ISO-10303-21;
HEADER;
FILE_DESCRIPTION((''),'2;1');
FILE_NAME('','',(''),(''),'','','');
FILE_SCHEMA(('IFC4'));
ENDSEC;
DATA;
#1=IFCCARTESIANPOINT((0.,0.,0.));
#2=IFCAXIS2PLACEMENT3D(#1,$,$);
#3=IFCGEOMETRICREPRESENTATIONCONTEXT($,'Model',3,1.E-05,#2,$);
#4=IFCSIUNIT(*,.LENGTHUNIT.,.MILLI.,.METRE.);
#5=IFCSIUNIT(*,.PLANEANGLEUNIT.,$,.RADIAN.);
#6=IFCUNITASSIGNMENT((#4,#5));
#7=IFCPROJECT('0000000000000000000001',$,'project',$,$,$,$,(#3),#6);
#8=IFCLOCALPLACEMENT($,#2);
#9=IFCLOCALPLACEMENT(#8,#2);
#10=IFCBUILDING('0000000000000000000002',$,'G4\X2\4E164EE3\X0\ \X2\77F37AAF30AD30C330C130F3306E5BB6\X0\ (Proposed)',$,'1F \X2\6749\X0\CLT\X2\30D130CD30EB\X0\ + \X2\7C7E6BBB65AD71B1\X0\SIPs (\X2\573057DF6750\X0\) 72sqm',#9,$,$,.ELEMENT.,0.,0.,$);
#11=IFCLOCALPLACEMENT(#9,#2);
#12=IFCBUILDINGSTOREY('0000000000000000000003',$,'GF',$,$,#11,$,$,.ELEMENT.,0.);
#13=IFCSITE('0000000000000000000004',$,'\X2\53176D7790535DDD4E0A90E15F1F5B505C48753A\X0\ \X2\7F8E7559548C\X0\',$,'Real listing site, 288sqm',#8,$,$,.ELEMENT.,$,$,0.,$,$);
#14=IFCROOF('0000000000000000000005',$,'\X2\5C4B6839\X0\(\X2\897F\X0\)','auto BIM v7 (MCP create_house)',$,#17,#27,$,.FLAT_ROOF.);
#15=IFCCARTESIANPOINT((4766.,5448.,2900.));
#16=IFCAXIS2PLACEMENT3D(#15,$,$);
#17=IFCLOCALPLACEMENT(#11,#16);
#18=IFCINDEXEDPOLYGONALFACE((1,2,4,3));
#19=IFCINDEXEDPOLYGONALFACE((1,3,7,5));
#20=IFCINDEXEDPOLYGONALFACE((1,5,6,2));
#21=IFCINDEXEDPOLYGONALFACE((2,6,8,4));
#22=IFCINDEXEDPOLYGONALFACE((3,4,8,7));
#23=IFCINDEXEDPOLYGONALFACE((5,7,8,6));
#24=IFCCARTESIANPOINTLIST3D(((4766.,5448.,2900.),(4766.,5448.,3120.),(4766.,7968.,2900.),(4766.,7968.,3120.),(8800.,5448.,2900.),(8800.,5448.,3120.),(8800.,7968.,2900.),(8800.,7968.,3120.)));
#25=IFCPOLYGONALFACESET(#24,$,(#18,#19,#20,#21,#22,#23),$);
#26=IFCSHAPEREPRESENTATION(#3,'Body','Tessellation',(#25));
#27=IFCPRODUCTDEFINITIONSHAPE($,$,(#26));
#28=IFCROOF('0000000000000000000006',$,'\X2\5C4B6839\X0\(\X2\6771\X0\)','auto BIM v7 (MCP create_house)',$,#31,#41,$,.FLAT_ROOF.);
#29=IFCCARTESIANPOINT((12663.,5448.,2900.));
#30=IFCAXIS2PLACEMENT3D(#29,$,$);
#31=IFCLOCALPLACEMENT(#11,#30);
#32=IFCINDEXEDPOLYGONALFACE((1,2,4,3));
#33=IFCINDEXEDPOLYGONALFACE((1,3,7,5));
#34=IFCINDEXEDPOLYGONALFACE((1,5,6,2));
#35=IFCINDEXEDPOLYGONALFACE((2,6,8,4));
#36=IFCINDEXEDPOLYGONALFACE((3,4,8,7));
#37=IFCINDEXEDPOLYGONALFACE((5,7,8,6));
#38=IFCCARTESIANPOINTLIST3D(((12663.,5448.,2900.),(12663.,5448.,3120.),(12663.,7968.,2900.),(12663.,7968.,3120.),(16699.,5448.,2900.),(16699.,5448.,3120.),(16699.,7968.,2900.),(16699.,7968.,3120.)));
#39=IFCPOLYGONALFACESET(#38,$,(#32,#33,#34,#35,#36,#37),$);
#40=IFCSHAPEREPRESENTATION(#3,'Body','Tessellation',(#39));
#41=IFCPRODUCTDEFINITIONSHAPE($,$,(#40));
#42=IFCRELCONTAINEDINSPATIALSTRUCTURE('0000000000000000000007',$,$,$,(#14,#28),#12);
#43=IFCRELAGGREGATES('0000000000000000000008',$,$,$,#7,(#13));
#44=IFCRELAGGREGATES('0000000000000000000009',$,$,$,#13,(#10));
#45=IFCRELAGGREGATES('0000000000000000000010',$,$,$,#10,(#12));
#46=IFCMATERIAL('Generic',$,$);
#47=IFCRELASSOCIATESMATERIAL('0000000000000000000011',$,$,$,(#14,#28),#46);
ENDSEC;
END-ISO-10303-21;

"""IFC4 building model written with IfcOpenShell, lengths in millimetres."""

from ifc_helpers import new_model, si_unit, frame, frame_2d, origin, place, context, project, spatial, rectangle, extrude, material, element, save


model = new_model("IFC4")

# Units and contexts
model_context = context("Model", 3, precision=1e-05, world=origin())
ifc_project = project(units=[si_unit("LENGTHUNIT", "METRE", prefix="MILLI"), si_unit("PLANEANGLEUNIT", "RADIAN")], contexts=[model_context])

# Site, building, storey
site_placement = place(None, origin())
site = spatial("IfcSite", under=ifc_project, at=site_placement, Name="北海道川上郡弟子屈町 美留和", ObjectType="Real listing site, 288sqm", CompositionType="ELEMENT", RefElevation=0.0)
building_placement = place(site_placement, origin())
building = spatial("IfcBuilding", under=site, at=building_placement, Name="G4世代 石窯キッチンの家 (Proposed)", ObjectType="1F 杉CLTパネル + 籾殻断熱SIPs (地域材) 72sqm", CompositionType="ELEMENT", ElevationOfRefHeight=0.0, ElevationOfTerrain=0.0)
storey_placement = place(building_placement, origin())
storey = spatial("IfcBuildingStorey", under=building, at=storey_placement, Name="GF", CompositionType="ELEMENT", Elevation=0.0)

# Shared definitions
ifc_material = material(Name="Generic")

# Roofs
roof_1_placement = place(storey_placement, frame((4766.0, 5448.0, 2900.0)))
element("IfcRoof", 1, at=roof_1_placement, inside=storey, material=ifc_material, Name="屋根(西)", Description="auto BIM v7 (MCP create_house)", PredefinedType="FLAT_ROOF", context=model_context, shape_type="SweptSolid", body=[
    extrude(rectangle(XDim=4034.0, YDim=2520.0, at=frame_2d((2017.0, 1260.0))), frame((4766.0, 5448.0, 2900.0)), (0.0, 0.0, 1.0), 220.0),
])
roof_2_placement = place(storey_placement, frame((12663.0, 5448.0, 2900.0)))
element("IfcRoof", 2, at=roof_2_placement, inside=storey, material=ifc_material, Name="屋根(東)", Description="auto BIM v7 (MCP create_house)", PredefinedType="FLAT_ROOF", context=model_context, shape_type="SweptSolid", body=[
    extrude(rectangle(XDim=4036.0, YDim=2520.0, at=frame_2d((2018.0, 1260.0))), frame((12663.0, 5448.0, 2900.0)), (0.0, 0.0, 1.0), 220.0),
])

save(model, "model.ifc")
